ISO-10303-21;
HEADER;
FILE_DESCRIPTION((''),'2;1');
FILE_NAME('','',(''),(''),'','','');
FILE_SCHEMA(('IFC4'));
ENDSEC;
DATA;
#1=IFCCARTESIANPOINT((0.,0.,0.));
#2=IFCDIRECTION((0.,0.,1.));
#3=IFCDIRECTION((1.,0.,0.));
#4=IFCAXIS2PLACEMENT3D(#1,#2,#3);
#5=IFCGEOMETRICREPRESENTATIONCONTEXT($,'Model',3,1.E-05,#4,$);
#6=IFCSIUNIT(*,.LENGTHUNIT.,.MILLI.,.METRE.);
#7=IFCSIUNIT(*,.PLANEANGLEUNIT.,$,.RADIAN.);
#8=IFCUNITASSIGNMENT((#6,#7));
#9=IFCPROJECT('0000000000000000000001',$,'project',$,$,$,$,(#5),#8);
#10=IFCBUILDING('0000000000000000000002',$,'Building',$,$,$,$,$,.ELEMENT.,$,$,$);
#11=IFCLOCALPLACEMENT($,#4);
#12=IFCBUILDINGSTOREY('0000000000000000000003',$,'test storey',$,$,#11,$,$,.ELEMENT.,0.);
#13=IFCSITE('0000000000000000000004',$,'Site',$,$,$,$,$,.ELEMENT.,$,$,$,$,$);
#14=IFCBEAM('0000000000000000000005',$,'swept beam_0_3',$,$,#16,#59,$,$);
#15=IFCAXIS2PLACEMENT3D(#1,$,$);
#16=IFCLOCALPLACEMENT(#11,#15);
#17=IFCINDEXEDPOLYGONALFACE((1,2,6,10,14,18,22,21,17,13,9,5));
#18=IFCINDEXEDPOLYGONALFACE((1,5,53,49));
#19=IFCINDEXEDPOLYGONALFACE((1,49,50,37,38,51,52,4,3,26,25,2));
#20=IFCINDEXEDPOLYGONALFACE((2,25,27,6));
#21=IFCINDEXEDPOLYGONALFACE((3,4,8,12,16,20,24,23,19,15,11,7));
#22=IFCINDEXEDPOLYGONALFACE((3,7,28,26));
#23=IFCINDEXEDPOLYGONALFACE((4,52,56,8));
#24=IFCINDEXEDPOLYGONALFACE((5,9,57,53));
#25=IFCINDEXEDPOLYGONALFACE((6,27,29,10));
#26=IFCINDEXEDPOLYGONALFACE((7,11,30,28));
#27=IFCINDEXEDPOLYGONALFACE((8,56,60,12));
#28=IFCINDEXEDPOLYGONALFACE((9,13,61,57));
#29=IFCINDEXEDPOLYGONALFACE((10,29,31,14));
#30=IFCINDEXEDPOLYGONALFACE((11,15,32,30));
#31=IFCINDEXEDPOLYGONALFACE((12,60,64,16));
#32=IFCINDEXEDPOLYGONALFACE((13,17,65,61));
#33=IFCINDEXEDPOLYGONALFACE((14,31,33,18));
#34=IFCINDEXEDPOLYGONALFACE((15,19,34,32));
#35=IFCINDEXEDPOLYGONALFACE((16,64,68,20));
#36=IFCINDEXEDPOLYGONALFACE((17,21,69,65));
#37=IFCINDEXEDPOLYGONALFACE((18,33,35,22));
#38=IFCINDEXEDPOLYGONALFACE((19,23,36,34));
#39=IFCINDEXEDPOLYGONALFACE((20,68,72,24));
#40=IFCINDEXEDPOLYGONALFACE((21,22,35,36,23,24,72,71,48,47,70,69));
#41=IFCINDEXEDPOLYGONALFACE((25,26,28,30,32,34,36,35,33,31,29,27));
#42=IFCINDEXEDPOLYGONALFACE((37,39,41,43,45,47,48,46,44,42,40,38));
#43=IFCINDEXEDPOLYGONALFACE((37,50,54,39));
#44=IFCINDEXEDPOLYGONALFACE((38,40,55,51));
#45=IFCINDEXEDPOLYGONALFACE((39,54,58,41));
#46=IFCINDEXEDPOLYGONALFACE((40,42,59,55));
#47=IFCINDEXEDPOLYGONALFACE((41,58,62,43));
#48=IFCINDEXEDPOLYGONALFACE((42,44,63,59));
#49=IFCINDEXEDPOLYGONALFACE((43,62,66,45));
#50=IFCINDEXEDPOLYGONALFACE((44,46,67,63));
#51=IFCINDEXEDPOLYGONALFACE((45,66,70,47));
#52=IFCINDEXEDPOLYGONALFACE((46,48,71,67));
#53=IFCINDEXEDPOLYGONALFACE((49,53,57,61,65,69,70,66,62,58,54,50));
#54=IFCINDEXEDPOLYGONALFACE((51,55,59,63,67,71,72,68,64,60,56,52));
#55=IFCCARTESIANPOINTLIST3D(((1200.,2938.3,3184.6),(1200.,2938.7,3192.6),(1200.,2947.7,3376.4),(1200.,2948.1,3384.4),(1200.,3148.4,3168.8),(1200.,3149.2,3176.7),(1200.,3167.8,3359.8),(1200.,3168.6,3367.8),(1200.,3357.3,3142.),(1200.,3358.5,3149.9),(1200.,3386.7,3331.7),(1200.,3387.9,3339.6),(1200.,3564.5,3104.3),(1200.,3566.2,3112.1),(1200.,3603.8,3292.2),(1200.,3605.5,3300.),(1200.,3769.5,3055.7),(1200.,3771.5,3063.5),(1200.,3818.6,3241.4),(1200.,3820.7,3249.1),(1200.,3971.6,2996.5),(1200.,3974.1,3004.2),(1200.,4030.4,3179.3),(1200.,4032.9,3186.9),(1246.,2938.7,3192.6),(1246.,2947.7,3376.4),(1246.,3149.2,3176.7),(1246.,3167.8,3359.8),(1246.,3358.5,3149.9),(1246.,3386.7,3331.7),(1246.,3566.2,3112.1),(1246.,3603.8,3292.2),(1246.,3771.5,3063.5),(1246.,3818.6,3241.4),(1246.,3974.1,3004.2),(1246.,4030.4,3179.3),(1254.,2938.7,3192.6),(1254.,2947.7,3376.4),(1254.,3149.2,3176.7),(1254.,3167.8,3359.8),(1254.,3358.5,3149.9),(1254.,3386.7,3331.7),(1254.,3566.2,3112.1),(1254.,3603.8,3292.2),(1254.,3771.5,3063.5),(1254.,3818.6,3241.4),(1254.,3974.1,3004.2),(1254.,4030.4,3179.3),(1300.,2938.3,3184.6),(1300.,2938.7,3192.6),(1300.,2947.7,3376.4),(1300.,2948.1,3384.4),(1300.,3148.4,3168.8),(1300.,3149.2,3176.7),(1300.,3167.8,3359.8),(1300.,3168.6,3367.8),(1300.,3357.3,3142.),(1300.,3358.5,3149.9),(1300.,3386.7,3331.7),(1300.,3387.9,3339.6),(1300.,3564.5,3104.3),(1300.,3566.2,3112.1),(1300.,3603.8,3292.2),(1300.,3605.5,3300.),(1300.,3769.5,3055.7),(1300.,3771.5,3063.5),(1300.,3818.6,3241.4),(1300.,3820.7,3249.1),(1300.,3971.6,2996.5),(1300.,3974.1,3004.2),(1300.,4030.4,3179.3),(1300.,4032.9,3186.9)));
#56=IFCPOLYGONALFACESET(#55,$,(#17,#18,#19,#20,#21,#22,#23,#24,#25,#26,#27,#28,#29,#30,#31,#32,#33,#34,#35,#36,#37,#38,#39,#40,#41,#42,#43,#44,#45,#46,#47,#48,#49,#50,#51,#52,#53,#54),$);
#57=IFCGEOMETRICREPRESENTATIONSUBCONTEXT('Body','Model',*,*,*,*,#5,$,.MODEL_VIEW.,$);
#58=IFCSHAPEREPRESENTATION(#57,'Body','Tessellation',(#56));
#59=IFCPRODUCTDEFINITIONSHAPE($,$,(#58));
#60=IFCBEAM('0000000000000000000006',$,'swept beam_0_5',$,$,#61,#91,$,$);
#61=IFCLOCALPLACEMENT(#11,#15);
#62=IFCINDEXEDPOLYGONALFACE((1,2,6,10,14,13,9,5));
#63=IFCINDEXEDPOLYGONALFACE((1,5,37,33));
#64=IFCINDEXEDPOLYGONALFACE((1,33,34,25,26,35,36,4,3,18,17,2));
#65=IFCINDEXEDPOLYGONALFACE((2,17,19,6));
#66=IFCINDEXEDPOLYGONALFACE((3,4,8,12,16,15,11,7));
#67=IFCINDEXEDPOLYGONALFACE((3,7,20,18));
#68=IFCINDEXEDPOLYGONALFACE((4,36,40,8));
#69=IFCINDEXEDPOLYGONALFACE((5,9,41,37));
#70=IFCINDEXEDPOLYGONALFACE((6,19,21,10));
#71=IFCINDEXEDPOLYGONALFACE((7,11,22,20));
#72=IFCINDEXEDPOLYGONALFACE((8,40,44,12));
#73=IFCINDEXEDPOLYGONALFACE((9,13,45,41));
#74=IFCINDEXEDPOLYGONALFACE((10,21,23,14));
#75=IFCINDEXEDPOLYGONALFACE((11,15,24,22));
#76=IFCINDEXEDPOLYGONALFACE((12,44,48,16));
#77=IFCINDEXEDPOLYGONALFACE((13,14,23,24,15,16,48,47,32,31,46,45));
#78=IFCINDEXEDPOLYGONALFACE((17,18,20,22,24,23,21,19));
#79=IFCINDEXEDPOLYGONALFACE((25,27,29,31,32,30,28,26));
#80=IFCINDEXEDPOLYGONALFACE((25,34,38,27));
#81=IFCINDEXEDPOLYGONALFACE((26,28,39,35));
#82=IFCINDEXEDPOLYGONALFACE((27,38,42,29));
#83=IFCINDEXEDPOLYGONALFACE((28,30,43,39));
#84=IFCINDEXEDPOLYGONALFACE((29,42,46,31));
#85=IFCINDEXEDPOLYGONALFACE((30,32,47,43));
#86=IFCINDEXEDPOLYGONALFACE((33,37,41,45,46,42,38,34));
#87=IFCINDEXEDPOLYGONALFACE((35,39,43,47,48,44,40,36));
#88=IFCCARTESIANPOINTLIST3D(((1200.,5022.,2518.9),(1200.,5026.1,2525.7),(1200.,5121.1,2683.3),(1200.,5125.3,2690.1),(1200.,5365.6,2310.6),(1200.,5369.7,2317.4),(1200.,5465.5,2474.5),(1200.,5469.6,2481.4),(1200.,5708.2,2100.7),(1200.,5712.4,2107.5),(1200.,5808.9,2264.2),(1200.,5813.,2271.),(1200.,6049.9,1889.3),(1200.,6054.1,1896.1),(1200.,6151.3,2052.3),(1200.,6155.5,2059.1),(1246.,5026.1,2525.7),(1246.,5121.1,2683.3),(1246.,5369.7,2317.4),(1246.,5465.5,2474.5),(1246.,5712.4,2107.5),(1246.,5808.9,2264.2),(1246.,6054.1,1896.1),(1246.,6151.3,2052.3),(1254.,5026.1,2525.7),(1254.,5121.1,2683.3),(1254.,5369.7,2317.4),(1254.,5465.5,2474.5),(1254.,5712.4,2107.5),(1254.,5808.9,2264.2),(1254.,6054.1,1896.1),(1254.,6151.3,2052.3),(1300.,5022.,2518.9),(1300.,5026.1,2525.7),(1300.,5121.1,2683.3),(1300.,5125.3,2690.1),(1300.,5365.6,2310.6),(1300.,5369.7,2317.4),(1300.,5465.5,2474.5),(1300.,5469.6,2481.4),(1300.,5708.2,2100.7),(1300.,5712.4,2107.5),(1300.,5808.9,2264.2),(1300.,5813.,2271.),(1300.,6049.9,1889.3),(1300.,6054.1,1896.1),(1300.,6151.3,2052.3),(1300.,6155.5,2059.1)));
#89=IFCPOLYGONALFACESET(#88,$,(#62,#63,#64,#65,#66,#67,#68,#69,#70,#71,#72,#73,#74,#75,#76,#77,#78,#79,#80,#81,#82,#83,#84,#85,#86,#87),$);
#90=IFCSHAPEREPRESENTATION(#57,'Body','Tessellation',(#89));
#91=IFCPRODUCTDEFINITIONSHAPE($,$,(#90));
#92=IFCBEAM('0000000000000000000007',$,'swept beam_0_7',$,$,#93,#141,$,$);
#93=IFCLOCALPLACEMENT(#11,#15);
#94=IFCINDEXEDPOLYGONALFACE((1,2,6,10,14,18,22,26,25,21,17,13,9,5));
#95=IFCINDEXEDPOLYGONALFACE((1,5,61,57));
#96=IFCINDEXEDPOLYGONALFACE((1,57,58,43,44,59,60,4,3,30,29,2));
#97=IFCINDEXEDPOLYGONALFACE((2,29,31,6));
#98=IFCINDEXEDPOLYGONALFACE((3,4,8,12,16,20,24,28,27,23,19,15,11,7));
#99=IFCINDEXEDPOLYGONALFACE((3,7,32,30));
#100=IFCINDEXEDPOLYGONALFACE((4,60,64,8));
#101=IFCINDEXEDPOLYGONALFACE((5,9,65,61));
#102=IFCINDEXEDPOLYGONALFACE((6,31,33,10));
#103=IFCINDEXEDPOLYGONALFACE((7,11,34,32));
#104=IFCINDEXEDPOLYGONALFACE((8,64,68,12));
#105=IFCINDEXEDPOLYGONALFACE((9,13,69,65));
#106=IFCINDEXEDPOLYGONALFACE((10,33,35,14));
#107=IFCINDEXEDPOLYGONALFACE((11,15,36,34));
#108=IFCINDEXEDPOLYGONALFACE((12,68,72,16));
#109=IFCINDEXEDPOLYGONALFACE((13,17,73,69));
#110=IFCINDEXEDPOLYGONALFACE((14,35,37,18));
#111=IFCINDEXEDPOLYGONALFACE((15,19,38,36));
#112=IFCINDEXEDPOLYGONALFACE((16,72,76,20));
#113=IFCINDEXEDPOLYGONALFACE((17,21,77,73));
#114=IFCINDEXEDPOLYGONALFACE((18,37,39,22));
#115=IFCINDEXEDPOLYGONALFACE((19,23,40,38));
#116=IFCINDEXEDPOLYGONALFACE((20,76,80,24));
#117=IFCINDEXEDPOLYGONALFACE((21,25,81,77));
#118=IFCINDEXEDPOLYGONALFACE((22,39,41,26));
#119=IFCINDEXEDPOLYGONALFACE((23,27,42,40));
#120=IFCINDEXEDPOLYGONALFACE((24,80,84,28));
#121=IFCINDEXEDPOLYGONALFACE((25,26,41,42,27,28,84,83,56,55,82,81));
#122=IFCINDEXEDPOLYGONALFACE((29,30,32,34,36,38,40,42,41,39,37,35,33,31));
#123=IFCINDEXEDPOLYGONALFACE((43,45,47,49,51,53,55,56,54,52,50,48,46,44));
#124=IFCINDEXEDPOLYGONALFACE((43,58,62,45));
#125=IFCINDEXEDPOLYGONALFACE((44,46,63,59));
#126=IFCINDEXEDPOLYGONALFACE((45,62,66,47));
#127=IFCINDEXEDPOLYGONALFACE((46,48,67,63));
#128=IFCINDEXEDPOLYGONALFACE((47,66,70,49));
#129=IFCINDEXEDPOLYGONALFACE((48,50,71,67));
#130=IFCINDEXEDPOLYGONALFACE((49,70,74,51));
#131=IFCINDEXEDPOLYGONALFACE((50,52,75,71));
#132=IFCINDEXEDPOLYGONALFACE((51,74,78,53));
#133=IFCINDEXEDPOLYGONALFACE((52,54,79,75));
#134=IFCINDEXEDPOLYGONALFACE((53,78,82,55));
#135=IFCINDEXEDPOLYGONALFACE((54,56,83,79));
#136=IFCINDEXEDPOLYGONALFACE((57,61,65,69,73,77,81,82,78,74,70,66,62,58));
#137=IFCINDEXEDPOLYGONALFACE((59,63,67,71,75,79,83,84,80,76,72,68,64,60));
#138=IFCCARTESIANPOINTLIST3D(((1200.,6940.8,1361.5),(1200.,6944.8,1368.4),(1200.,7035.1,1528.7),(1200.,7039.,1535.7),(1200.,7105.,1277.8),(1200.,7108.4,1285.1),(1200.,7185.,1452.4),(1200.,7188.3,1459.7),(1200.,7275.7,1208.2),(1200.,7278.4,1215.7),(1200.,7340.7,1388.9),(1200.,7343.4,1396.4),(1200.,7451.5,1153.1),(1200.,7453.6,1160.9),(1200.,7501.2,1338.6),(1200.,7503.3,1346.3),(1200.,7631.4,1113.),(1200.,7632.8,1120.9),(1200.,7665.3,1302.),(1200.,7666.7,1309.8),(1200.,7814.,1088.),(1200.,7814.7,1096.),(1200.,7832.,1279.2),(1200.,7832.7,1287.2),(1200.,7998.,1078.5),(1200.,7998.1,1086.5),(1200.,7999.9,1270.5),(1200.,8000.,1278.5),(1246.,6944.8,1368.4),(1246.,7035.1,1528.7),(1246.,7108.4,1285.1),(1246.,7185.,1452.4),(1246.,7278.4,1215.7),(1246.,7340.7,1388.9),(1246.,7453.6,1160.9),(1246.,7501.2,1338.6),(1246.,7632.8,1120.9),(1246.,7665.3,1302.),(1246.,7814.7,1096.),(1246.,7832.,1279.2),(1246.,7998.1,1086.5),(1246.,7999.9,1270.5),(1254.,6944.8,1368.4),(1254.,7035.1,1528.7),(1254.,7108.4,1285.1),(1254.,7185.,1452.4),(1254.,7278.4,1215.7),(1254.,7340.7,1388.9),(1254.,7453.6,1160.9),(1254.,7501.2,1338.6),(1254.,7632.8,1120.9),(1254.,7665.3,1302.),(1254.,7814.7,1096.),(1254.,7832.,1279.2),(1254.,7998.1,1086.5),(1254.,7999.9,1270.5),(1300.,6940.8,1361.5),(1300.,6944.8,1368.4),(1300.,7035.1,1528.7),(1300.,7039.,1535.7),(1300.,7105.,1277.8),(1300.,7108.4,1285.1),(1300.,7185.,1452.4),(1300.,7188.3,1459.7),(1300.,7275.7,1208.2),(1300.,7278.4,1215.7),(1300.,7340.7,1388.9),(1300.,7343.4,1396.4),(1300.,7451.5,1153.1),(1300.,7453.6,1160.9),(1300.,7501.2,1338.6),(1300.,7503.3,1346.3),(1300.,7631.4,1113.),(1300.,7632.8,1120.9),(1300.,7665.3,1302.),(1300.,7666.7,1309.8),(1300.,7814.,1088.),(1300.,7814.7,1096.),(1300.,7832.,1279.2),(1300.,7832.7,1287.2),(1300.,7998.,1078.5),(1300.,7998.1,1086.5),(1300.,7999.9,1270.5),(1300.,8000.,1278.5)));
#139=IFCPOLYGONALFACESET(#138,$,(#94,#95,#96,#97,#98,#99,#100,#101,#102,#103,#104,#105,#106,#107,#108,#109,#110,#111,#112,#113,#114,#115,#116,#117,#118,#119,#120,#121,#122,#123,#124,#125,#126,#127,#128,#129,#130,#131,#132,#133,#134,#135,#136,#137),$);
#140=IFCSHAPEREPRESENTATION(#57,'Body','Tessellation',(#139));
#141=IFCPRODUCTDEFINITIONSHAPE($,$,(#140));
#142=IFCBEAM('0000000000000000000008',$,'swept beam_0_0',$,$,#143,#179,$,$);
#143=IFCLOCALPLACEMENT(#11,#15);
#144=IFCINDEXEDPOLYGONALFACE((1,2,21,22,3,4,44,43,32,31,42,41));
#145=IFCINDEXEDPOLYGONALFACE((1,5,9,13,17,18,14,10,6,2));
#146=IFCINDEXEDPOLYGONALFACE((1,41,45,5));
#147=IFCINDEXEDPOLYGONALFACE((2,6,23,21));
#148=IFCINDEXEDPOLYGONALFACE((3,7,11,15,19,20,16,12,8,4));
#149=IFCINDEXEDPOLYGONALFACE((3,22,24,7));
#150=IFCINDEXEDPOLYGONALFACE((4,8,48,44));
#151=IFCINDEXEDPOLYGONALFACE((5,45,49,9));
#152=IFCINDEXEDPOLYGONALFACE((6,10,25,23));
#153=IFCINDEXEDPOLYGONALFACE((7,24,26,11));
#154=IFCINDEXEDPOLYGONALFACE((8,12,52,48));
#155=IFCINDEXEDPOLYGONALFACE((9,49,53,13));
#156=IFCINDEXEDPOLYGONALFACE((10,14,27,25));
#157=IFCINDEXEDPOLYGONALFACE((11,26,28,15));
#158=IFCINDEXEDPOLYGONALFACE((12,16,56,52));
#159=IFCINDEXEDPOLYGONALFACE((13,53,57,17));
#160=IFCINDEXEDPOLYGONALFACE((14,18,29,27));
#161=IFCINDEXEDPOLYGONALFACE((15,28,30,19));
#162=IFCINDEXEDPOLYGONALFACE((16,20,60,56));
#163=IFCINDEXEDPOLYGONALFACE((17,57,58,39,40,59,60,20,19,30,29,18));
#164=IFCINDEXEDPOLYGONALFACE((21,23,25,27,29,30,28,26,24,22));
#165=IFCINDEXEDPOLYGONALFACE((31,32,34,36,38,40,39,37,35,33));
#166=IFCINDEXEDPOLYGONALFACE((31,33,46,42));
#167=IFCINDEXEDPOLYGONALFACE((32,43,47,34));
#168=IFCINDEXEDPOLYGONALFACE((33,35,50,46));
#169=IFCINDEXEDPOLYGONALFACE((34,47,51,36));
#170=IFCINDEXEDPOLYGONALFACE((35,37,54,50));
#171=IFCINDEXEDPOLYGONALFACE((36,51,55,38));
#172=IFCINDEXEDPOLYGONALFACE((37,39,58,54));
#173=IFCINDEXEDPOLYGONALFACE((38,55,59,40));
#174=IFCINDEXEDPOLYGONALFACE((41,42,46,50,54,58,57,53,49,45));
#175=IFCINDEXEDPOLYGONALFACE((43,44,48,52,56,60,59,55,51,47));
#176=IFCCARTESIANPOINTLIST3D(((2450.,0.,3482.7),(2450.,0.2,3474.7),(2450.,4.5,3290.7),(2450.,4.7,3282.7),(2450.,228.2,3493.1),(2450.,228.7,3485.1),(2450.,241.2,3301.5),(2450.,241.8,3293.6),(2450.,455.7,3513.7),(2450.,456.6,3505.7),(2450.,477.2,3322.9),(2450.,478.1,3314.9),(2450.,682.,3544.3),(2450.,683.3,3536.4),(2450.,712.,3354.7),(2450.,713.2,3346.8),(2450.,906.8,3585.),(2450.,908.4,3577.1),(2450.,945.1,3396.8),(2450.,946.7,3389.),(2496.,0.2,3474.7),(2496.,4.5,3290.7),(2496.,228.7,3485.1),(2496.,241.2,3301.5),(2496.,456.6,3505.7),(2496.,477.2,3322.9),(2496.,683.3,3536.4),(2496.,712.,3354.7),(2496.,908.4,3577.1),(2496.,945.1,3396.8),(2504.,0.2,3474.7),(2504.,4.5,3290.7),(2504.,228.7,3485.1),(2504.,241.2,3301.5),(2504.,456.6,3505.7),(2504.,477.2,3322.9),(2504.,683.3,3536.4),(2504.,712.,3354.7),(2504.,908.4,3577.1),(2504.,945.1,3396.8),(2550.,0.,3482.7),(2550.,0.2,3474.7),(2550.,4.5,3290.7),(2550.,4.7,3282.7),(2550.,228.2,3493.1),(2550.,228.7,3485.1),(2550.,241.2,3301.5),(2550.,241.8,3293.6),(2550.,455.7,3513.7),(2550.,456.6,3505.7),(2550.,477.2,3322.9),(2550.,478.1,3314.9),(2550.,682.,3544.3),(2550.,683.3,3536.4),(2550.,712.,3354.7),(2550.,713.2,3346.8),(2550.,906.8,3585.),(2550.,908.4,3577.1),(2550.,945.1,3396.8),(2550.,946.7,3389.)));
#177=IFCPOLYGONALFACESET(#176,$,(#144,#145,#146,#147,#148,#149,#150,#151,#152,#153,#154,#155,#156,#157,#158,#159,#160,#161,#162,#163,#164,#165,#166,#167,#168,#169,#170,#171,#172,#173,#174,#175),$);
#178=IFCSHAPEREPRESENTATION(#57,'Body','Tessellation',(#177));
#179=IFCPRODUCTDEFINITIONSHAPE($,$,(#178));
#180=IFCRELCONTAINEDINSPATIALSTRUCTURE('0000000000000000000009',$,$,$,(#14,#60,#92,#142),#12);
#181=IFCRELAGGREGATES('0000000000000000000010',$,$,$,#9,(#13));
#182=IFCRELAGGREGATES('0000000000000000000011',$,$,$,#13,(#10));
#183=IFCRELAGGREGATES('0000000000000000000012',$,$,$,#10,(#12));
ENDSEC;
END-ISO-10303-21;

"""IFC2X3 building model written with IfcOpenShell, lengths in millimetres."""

from ifc_helpers import new_model, entity, si_unit, origin_with_axes, place, context, subcontext, project, spatial, element, save


model = new_model("IFC2X3")

# Units and contexts
model_context = context("Model", 3, precision=1e-05, world=origin_with_axes())
body_context = subcontext(model_context, "Body", "Model", "MODEL_VIEW")
ifc_project = project(units=[si_unit("LENGTHUNIT", "METRE", prefix="MILLI"), si_unit("PLANEANGLEUNIT", "RADIAN")], contexts=[model_context])

# Site, building, storey
site = spatial("IfcSite", under=ifc_project, Name="Site", CompositionType="ELEMENT")
building = spatial("IfcBuilding", under=site, Name="Building", CompositionType="ELEMENT")
storey_placement = place(None, origin_with_axes())
storey = spatial("IfcBuildingStorey", under=building, at=storey_placement, Name="test storey", CompositionType="ELEMENT", Elevation=0.0)

# Beams
beam_1_placement = place(storey_placement, origin_with_axes())
element("IfcBeam", 1, at=beam_1_placement, inside=storey, Name="swept beam_0_3", context=body_context, shape_type="SweptSolid", body=[
    entity("IfcRevolvedAreaSolid", entity("IfcArbitraryClosedProfileDef", "AREA", None, entity("IfcPolyline", [entity("IfcCartesianPoint", [-192.0, -50.0]), entity("IfcCartesianPoint", [-192.0, -4.0]), entity("IfcCartesianPoint", [-8.0, -4.0]), entity("IfcCartesianPoint", [-8.0, -50.0]), entity("IfcCartesianPoint", [0.0, -50.0]), entity("IfcCartesianPoint", [0.0, 50.0]), entity("IfcCartesianPoint", [-8.0, 50.0]), entity("IfcCartesianPoint", [-8.0, 4.0]), entity("IfcCartesianPoint", [-192.0, 4.0]), entity("IfcCartesianPoint", [-192.0, 50.0]), entity("IfcCartesianPoint", [-200.0, 50.0]), entity("IfcCartesianPoint", [-200.0, -50.0]), entity("IfcCartesianPoint", [-192.0, -50.0])])), entity("IfcAxis2Placement3D", entity("IfcCartesianPoint", [1250.0, 2948.1, 3384.4]), entity("IfcDirection", [0.0, -0.9988, 0.0489]), entity("IfcDirection", [0.0, 0.0489, 0.9988])), entity("IfcAxis1Placement", entity("IfcCartesianPoint", [-4216.9, 0.0, 0.0]), entity("IfcDirection", [0.0, 1.0, 0.0])), 0.262208),
])
beam_2_placement = place(storey_placement, origin_with_axes())
element("IfcBeam", 2, at=beam_2_placement, inside=storey, Name="swept beam_0_5", context=body_context, shape_type="SweptSolid", body=[
    entity("IfcRevolvedAreaSolid", entity("IfcArbitraryClosedProfileDef", "AREA", None, entity("IfcPolyline", [entity("IfcCartesianPoint", [-192.0, -50.0]), entity("IfcCartesianPoint", [-192.0, -4.0]), entity("IfcCartesianPoint", [-8.0, -4.0]), entity("IfcCartesianPoint", [-8.0, -50.0]), entity("IfcCartesianPoint", [0.0, -50.0]), entity("IfcCartesianPoint", [0.0, 50.0]), entity("IfcCartesianPoint", [-8.0, 50.0]), entity("IfcCartesianPoint", [-8.0, 4.0]), entity("IfcCartesianPoint", [-192.0, 4.0]), entity("IfcCartesianPoint", [-192.0, 50.0]), entity("IfcCartesianPoint", [-200.0, 50.0]), entity("IfcCartesianPoint", [-200.0, -50.0]), entity("IfcCartesianPoint", [-192.0, -50.0])])), entity("IfcAxis2Placement3D", entity("IfcCartesianPoint", [1250.0, 5125.3, 2690.1]), entity("IfcDirection", [0.0, -0.8563, 0.5164]), entity("IfcDirection", [0.0, 0.5164, 0.8563])), entity("IfcAxis1Placement", entity("IfcCartesianPoint", [-87503.1, 0.0, 0.0]), entity("IfcDirection", [0.0, 1.0, 0.0])), 0.013807),
])
beam_3_placement = place(storey_placement, origin_with_axes())
element("IfcBeam", 3, at=beam_3_placement, inside=storey, Name="swept beam_0_7", context=body_context, shape_type="SweptSolid", body=[
    entity("IfcRevolvedAreaSolid", entity("IfcArbitraryClosedProfileDef", "AREA", None, entity("IfcPolyline", [entity("IfcCartesianPoint", [192.0, 50.0]), entity("IfcCartesianPoint", [192.0, 4.0]), entity("IfcCartesianPoint", [8.0, 4.0]), entity("IfcCartesianPoint", [8.0, 50.0]), entity("IfcCartesianPoint", [0.0, 50.0]), entity("IfcCartesianPoint", [0.0, -50.0]), entity("IfcCartesianPoint", [8.0, -50.0]), entity("IfcCartesianPoint", [8.0, -4.0]), entity("IfcCartesianPoint", [192.0, -4.0]), entity("IfcCartesianPoint", [192.0, -50.0]), entity("IfcCartesianPoint", [200.0, -50.0]), entity("IfcCartesianPoint", [200.0, 50.0]), entity("IfcCartesianPoint", [192.0, 50.0])])), entity("IfcAxis2Placement3D", entity("IfcCartesianPoint", [1250.0, 7039.0, 1535.7]), entity("IfcDirection", [0.0, -0.8712, 0.4909]), entity("IfcDirection", [0.0, -0.4909, -0.8712])), entity("IfcAxis1Placement", entity("IfcCartesianPoint", [-1998.2, 0.0, 0.0]), entity("IfcDirection", [0.0, 1.0, 0.0])), 0.503157),
])
beam_4_placement = place(storey_placement, origin_with_axes())
element("IfcBeam", 4, at=beam_4_placement, inside=storey, Name="swept beam_0_0", context=body_context, shape_type="SweptSolid", body=[
    entity("IfcRevolvedAreaSolid", entity("IfcArbitraryClosedProfileDef", "AREA", None, entity("IfcPolyline", [entity("IfcCartesianPoint", [192.0, 50.0]), entity("IfcCartesianPoint", [192.0, 4.0]), entity("IfcCartesianPoint", [8.0, 4.0]), entity("IfcCartesianPoint", [8.0, 50.0]), entity("IfcCartesianPoint", [0.0, 50.0]), entity("IfcCartesianPoint", [0.0, -50.0]), entity("IfcCartesianPoint", [8.0, -50.0]), entity("IfcCartesianPoint", [8.0, -4.0]), entity("IfcCartesianPoint", [192.0, -4.0]), entity("IfcCartesianPoint", [192.0, -50.0]), entity("IfcCartesianPoint", [200.0, -50.0]), entity("IfcCartesianPoint", [200.0, 50.0]), entity("IfcCartesianPoint", [192.0, 50.0])])), entity("IfcAxis2Placement3D", entity("IfcCartesianPoint", [2500.0, 0.0, 3482.7]), entity("IfcDirection", [0.0, -0.9997, -0.0236]), entity("IfcDirection", [0.0, 0.0236, -0.9997])), entity("IfcAxis1Placement", entity("IfcCartesianPoint", [-5148.5, 0.0, 0.0]), entity("IfcDirection", [0.0, 1.0, 0.0])), 0.177478),
])

save(model, "model.ifc")
